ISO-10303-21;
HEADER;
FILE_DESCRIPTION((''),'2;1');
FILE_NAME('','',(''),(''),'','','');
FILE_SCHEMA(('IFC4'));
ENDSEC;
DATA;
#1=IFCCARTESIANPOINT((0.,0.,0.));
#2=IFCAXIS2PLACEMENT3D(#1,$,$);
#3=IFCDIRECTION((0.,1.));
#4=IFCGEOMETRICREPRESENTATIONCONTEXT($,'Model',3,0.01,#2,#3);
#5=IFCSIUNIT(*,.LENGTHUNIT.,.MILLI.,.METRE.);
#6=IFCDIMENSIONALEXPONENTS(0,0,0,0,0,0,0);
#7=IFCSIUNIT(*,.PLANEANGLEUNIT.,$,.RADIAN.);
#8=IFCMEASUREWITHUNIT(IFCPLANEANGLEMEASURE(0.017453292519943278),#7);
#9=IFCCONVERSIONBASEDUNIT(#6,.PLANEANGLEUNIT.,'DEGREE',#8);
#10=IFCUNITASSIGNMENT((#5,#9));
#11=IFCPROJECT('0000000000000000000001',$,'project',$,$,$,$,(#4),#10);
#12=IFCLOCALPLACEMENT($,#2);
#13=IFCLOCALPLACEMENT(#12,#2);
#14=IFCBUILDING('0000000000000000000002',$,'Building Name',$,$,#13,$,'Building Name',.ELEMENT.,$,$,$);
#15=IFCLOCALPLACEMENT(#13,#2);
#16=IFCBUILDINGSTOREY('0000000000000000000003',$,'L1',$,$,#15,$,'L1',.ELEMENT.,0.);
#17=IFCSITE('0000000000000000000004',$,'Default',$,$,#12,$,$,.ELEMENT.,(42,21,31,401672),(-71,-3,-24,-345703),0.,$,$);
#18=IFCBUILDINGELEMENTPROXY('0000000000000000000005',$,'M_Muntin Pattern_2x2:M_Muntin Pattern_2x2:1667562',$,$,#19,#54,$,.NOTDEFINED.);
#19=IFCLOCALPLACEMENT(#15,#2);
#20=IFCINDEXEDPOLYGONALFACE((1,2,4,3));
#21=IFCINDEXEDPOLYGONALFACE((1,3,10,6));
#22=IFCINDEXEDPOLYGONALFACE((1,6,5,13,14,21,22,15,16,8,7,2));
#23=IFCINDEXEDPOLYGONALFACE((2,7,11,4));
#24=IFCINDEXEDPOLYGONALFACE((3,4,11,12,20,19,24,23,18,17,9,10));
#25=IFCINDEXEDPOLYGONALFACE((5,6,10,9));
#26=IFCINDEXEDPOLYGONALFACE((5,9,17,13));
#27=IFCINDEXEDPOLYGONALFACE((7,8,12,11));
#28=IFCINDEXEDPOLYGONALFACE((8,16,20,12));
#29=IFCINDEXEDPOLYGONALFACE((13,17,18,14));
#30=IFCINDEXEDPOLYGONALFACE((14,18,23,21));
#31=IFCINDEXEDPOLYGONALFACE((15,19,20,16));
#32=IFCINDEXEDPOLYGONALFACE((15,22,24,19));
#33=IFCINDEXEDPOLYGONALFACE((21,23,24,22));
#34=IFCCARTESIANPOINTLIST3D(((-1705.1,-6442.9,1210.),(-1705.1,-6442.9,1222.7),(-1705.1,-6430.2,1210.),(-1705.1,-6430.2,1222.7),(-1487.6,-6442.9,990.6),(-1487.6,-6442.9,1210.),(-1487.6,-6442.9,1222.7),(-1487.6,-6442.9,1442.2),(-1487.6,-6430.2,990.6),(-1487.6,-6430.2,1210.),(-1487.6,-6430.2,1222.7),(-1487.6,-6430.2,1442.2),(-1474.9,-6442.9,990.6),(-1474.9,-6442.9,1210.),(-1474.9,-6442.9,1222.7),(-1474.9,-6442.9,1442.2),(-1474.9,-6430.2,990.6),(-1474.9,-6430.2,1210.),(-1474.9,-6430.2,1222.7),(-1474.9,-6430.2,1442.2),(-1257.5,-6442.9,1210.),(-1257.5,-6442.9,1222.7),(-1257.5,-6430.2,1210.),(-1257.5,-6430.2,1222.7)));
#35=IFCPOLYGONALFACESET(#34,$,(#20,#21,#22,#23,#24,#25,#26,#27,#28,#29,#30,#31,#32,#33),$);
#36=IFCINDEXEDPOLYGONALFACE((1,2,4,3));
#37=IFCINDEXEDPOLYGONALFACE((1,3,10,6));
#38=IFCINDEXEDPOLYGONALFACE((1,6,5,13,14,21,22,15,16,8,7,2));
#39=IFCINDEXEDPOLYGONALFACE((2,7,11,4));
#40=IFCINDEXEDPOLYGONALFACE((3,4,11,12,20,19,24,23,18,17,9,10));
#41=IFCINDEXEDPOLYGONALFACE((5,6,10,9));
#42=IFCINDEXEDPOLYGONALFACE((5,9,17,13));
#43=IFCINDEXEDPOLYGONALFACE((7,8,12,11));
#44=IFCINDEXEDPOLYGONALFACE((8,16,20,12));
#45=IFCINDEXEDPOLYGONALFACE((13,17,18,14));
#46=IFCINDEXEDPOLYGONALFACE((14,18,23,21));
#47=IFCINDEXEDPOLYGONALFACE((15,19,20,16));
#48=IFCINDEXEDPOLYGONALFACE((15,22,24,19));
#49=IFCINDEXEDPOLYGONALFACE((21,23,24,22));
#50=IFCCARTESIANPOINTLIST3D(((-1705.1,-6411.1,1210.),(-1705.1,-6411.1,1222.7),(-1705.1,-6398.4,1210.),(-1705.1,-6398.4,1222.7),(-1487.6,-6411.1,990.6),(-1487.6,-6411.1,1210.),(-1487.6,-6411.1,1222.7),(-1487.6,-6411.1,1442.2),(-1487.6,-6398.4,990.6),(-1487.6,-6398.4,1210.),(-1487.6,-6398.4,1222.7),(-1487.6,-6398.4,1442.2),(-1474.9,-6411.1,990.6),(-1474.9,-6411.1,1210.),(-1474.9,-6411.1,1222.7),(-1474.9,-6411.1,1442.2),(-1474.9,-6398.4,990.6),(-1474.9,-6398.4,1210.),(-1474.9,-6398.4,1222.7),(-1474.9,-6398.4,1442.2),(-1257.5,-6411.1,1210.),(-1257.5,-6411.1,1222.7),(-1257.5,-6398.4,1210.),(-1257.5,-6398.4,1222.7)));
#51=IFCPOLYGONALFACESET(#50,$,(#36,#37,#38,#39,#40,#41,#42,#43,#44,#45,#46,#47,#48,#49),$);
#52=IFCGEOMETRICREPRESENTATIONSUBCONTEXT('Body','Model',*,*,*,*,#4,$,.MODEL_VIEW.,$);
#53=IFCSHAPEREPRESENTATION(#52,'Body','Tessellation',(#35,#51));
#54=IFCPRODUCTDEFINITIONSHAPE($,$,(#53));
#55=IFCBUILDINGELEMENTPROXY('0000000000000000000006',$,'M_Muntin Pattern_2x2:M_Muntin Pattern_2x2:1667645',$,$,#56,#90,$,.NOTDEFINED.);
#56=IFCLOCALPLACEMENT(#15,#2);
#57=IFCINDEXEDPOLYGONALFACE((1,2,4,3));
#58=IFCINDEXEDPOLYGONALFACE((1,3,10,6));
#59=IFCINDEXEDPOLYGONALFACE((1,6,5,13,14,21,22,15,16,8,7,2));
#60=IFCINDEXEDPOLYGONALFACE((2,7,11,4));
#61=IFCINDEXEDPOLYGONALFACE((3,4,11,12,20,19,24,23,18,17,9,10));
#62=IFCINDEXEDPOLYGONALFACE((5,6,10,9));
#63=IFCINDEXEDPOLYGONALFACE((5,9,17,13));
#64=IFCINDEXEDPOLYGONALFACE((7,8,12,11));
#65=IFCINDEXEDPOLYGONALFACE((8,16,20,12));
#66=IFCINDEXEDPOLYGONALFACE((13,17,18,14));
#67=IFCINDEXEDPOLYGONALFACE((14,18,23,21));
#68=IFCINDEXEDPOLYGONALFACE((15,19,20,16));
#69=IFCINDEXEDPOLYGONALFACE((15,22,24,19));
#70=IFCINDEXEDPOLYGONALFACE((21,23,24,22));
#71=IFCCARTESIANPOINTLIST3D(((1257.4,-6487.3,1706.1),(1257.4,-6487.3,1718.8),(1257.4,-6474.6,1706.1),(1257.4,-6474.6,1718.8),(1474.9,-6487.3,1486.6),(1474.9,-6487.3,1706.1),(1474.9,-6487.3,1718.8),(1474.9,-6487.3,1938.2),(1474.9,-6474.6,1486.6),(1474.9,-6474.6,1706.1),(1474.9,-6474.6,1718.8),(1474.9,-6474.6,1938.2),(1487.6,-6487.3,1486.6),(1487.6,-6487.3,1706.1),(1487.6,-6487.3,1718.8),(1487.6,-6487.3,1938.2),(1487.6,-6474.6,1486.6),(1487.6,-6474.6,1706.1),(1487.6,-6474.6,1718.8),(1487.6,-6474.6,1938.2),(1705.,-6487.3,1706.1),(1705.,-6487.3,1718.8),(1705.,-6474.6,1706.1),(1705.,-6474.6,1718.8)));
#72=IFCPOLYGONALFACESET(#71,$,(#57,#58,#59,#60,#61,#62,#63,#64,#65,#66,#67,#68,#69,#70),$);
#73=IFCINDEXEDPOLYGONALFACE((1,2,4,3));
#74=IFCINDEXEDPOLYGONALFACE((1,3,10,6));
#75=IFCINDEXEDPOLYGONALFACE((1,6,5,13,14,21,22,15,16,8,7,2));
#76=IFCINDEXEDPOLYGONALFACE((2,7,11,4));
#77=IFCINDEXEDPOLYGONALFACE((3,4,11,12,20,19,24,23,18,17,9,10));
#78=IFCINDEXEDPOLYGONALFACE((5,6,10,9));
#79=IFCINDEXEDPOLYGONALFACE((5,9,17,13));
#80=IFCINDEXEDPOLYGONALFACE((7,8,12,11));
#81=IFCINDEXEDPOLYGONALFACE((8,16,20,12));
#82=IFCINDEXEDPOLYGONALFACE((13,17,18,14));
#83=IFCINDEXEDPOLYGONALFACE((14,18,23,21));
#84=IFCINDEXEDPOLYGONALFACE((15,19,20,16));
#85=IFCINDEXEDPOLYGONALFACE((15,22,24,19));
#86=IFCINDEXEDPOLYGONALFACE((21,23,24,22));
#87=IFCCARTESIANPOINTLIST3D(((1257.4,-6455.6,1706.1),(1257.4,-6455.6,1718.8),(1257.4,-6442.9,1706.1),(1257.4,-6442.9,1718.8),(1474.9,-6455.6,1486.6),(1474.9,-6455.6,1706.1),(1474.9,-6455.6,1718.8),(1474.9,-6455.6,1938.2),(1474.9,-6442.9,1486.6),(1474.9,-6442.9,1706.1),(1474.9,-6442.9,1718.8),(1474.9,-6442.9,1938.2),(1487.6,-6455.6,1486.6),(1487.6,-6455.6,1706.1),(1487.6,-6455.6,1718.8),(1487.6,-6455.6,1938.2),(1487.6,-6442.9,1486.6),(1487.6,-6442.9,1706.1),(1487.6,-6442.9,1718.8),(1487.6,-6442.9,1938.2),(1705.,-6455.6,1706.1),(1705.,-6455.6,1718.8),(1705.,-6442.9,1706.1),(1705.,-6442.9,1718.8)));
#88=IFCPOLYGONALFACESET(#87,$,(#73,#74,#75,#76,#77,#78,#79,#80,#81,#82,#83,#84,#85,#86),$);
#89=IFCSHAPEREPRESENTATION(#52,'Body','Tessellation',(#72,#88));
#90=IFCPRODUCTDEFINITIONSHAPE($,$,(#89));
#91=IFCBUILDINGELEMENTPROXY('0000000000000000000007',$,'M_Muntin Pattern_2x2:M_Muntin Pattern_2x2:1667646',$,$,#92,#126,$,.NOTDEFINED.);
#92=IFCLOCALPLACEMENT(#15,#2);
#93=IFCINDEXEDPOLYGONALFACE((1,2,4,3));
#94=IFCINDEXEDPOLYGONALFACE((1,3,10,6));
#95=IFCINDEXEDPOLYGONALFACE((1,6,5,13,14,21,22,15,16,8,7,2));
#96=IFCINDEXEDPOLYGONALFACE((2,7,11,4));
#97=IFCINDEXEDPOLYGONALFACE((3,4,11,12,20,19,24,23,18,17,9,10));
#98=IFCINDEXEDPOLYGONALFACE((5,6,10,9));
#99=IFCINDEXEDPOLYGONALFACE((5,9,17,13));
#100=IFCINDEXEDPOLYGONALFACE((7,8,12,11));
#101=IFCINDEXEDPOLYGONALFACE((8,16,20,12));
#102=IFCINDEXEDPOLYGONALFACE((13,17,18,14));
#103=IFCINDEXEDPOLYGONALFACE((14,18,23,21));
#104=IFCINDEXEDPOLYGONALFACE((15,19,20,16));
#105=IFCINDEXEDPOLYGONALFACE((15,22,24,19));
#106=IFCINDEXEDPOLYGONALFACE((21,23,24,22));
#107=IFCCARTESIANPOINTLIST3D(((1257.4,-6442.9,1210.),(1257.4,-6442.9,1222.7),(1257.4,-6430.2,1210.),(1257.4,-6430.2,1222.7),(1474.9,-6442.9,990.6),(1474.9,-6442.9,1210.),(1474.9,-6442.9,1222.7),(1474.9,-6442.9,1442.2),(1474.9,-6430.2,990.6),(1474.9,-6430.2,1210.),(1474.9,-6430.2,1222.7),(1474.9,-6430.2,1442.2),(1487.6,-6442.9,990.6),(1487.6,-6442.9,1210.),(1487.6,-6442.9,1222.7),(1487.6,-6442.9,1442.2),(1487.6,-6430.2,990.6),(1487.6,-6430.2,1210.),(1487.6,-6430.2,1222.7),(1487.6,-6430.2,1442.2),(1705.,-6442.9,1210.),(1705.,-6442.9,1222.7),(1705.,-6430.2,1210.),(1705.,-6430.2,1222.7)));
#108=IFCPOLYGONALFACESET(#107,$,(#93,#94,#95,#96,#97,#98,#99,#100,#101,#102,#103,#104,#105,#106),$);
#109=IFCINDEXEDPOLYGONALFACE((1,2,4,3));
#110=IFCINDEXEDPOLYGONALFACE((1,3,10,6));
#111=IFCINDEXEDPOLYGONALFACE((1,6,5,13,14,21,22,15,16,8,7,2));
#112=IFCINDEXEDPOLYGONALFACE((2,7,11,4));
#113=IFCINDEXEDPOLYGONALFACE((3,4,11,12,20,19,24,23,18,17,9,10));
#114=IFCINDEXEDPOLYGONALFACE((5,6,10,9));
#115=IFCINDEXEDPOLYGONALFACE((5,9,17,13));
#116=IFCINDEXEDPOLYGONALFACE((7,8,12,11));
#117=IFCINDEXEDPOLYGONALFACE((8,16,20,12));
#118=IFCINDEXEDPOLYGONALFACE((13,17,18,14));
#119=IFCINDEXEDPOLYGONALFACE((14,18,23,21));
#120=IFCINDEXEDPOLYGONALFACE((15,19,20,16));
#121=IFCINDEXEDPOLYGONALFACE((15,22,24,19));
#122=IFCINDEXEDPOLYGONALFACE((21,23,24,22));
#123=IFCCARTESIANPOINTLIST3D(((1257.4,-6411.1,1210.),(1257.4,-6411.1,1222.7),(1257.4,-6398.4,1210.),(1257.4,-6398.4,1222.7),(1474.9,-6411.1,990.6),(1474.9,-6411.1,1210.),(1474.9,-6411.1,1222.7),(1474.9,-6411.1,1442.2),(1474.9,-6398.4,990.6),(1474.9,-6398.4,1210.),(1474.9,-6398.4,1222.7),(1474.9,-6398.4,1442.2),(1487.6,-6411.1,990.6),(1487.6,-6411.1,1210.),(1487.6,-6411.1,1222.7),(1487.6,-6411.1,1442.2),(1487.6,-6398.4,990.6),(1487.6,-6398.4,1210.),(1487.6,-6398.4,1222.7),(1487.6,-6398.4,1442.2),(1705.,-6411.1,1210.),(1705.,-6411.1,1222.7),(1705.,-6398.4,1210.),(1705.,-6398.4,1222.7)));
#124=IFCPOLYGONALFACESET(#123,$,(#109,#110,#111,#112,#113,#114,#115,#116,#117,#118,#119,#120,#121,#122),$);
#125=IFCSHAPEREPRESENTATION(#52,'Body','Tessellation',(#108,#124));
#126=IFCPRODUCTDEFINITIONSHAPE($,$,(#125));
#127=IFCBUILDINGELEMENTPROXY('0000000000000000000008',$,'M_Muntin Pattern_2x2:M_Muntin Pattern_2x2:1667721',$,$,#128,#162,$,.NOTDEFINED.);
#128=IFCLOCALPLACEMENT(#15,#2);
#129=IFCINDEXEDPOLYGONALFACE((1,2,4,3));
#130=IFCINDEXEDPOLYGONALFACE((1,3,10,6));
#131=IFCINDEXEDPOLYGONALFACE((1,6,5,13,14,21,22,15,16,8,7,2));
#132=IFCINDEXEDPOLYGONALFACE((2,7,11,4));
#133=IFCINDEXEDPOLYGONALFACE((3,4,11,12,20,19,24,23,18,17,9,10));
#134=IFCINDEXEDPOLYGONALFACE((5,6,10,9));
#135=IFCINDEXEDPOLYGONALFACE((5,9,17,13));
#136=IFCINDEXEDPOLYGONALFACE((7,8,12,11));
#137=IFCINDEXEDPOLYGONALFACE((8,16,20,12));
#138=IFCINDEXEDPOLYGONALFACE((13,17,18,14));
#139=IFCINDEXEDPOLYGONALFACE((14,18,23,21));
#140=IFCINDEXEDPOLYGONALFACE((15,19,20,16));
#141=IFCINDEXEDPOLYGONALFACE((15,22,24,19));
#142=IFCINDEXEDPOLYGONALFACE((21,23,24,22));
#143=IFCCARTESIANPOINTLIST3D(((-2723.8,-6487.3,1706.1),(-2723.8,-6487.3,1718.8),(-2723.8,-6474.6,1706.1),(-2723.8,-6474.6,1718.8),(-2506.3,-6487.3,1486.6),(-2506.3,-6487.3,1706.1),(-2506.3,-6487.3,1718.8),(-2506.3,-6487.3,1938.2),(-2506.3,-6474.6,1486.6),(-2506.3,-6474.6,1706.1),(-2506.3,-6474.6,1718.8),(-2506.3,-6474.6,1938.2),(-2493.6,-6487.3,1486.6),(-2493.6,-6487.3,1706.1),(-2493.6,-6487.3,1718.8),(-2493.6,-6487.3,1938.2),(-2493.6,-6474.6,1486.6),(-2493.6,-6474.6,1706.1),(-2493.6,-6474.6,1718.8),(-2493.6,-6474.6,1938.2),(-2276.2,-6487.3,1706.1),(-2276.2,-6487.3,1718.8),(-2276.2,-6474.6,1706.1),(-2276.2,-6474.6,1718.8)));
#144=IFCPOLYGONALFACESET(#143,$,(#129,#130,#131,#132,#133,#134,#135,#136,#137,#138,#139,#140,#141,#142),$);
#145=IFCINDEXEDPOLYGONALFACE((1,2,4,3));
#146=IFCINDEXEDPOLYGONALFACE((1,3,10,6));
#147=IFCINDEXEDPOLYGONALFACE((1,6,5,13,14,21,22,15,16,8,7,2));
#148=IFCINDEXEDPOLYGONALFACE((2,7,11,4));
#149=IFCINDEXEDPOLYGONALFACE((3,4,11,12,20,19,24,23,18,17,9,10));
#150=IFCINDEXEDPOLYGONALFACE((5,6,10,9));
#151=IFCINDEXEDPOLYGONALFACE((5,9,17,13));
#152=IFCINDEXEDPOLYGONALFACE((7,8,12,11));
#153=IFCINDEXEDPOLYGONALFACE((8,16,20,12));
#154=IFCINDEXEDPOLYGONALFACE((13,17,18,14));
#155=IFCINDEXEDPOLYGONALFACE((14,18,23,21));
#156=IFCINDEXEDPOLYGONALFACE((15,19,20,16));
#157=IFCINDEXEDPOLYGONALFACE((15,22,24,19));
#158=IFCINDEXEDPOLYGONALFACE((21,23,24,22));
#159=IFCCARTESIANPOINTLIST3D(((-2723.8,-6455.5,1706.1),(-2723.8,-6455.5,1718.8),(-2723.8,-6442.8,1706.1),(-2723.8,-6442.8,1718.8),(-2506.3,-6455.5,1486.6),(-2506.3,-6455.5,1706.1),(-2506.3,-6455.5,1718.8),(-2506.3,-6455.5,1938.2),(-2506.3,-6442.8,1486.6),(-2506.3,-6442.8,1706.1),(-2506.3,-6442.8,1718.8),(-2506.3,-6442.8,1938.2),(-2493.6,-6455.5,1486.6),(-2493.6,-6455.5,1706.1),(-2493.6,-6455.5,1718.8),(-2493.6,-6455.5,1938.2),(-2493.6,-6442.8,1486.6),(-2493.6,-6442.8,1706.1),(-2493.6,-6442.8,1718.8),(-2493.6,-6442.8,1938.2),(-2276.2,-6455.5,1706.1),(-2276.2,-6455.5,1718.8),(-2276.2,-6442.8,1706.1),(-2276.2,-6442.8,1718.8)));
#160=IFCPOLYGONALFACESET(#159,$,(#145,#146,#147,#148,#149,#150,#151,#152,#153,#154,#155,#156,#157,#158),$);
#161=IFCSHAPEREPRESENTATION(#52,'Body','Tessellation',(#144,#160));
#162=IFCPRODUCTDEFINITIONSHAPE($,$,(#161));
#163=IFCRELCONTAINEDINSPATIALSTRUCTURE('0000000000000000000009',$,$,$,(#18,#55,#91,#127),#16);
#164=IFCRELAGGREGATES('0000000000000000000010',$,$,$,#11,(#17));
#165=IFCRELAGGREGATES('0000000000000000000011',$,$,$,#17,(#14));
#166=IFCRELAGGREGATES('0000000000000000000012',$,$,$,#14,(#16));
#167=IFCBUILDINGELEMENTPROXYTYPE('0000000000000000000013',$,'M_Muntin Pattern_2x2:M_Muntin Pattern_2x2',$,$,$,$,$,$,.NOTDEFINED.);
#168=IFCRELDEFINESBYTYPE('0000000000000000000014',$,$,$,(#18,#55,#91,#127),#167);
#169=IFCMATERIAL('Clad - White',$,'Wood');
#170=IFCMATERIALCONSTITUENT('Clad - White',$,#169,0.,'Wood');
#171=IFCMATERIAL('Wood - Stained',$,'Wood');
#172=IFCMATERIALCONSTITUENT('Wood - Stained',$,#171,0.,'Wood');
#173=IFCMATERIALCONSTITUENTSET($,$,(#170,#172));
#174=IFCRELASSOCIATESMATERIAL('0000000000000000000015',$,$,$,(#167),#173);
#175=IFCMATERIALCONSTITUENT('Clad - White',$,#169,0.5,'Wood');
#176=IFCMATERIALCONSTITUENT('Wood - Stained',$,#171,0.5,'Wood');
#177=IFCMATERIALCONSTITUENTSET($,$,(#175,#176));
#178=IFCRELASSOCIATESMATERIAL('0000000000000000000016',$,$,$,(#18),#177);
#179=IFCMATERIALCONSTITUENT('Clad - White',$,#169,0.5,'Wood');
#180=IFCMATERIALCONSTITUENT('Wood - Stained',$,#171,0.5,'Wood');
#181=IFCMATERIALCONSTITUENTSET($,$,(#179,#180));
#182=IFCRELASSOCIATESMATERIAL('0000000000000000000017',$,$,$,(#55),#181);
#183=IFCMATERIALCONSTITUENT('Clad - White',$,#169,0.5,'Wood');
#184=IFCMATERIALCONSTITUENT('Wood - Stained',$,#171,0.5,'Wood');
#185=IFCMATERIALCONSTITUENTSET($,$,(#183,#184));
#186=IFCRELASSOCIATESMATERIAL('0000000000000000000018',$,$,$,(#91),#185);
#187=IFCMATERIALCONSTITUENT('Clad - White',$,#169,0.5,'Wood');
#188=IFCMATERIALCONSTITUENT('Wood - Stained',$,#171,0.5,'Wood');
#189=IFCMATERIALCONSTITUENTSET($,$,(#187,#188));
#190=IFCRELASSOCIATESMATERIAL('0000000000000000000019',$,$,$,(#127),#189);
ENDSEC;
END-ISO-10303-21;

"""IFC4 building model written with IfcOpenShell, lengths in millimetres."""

from ifc_helpers import new_model, entity, si_unit, converted_unit, direction, frame, origin, place, context, subcontext, project, spatial, indexed_curve, outline, extrude, source, transform, mapped, material, constituent, constituent_set, type_object, type_shapes, element, save


model = new_model("IFC4")

# Units and contexts
model_context = context("Model", 3, precision=0.01, world=origin(), true_north=direction((0.0, 1.0)))
body_context = subcontext(model_context, "Body", "Model", "MODEL_VIEW")
ifc_project = project(units=[si_unit("LENGTHUNIT", "METRE", prefix="MILLI"), converted_unit("PLANEANGLEUNIT", "DEGREE", entity("IfcPlaneAngleMeasure", 0.017453292519943278), si_unit("PLANEANGLEUNIT", "RADIAN"), dimensions=[0, 0, 0, 0, 0, 0, 0])], contexts=[model_context])

# Site, building, storey
site_placement = place(None, origin())
site = spatial("IfcSite", under=ifc_project, at=site_placement, Name="Default", CompositionType="ELEMENT", RefLatitude=(42, 21, 31, 401672), RefLongitude=(-71, -3, -24, -345703), RefElevation=0.0)
building_placement = place(site_placement, origin())
building = spatial("IfcBuilding", under=site, at=building_placement, Name="Building Name", LongName="Building Name", CompositionType="ELEMENT")
storey_placement = place(building_placement, origin())
storey = spatial("IfcBuildingStorey", under=building, at=storey_placement, Name="L1", LongName="L1", CompositionType="ELEMENT", Elevation=0.0)

# Building element proxies
ifc_material_1 = material(Name="Clad - White", Category="Wood")
ifc_material_2 = material(Name="Wood - Stained", Category="Wood")
ifc_constituent_1 = constituent(ifc_material_1, Name="Clad - White", Category="Wood", fraction=0.0)
ifc_constituent_2 = constituent(ifc_material_2, Name="Wood - Stained", Category="Wood", fraction=0.0)
ifc_constituent_set_1 = constituent_set(constituents=[ifc_constituent_1, ifc_constituent_2])
building_element_proxy_type_1 = type_object("IfcBuildingElementProxyType", Name="M_Muntin Pattern_2x2:M_Muntin Pattern_2x2", PredefinedType="NOTDEFINED", material=ifc_constituent_set_1)
shared_shape_1 = source(origin(), body_context, "Body", "SweptSolid", [
    extrude(outline(indexed_curve([(6.4, -6.4), (225.8, -6.4), (225.8, 6.3), (6.4, 6.3), (6.4, 223.8), (-6.3, 223.8), (-6.3, 6.3), (-225.8, 6.3), (-225.8, -6.4), (-6.3, -6.4), (-6.3, -223.8), (6.4, -223.8), (6.4, -6.4)], self_intersect=False)), frame((0.0, 9.5, 225.8), z_axis=(0.0, 1.0, 0.0), x_axis=(0.0, 0.0, 1.0)), (0.0, 0.0, 1.0), 12.7),
    extrude(outline(indexed_curve([(6.4, -6.4), (225.8, -6.4), (225.8, 6.3), (6.4, 6.3), (6.4, 223.8), (-6.3, 223.8), (-6.3, 6.3), (-225.8, 6.3), (-225.8, -6.4), (-6.3, -6.4), (-6.3, -223.8), (6.4, -223.8), (6.4, -6.4)], self_intersect=False)), frame((0.0, -22.2, 225.8), z_axis=(0.0, 1.0, 0.0), x_axis=(0.0, 0.0, 1.0)), (0.0, 0.0, 1.0), 12.7),
])
type_shapes(building_element_proxy_type_1, [shared_shape_1])
ifc_constituent_3 = constituent(ifc_material_1, Name="Clad - White", Category="Wood", fraction=0.5)
ifc_constituent_4 = constituent(ifc_material_2, Name="Wood - Stained", Category="Wood", fraction=0.5)
ifc_constituent_set_2 = constituent_set(constituents=[ifc_constituent_3, ifc_constituent_4])
proxy_1_placement = place(storey_placement, frame((-1481.2, -6420.6, 990.6), z_axis=(0.0, 0.0, 1.0), x_axis=(-1.0, 0.0, 0.0)))
element("IfcBuildingElementProxy", 1, at=proxy_1_placement, inside=storey, type_object=building_element_proxy_type_1, material=ifc_constituent_set_2, Name="M_Muntin Pattern_2x2:M_Muntin Pattern_2x2:1667562", PredefinedType="NOTDEFINED", context=body_context, shape_type="MappedRepresentation", body=[
    mapped(shared_shape_1, transform((0.0, 0.0, 0.0), scale=1.0)),
])
ifc_constituent_5 = constituent(ifc_material_1, Name="Clad - White", Category="Wood", fraction=0.5)
ifc_constituent_6 = constituent(ifc_material_2, Name="Wood - Stained", Category="Wood", fraction=0.5)
ifc_constituent_set_3 = constituent_set(constituents=[ifc_constituent_5, ifc_constituent_6])
proxy_2_placement = place(storey_placement, frame((1481.3, -6465.1, 1486.6), z_axis=(0.0, 0.0, 1.0), x_axis=(-1.0, 0.0, 0.0)))
element("IfcBuildingElementProxy", 2, at=proxy_2_placement, inside=storey, type_object=building_element_proxy_type_1, material=ifc_constituent_set_3, Name="M_Muntin Pattern_2x2:M_Muntin Pattern_2x2:1667645", PredefinedType="NOTDEFINED", context=body_context, shape_type="MappedRepresentation", body=[
    mapped(shared_shape_1, transform((0.0, 0.0, 0.0), scale=1.0)),
])
ifc_constituent_7 = constituent(ifc_material_1, Name="Clad - White", Category="Wood", fraction=0.5)
ifc_constituent_8 = constituent(ifc_material_2, Name="Wood - Stained", Category="Wood", fraction=0.5)
ifc_constituent_set_4 = constituent_set(constituents=[ifc_constituent_7, ifc_constituent_8])
proxy_3_placement = place(storey_placement, frame((1481.3, -6420.6, 990.6), z_axis=(0.0, 0.0, 1.0), x_axis=(-1.0, 0.0, 0.0)))
element("IfcBuildingElementProxy", 3, at=proxy_3_placement, inside=storey, type_object=building_element_proxy_type_1, material=ifc_constituent_set_4, Name="M_Muntin Pattern_2x2:M_Muntin Pattern_2x2:1667646", PredefinedType="NOTDEFINED", context=body_context, shape_type="MappedRepresentation", body=[
    mapped(shared_shape_1, transform((0.0, 0.0, 0.0), scale=1.0)),
])
ifc_constituent_9 = constituent(ifc_material_1, Name="Clad - White", Category="Wood", fraction=0.5)
ifc_constituent_10 = constituent(ifc_material_2, Name="Wood - Stained", Category="Wood", fraction=0.5)
ifc_constituent_set_5 = constituent_set(constituents=[ifc_constituent_9, ifc_constituent_10])
proxy_4_placement = place(storey_placement, frame((-2500.0, -6465.1, 1486.6), z_axis=(0.0, 0.0, 1.0), x_axis=(-1.0, 0.0, 0.0)))
element("IfcBuildingElementProxy", 4, at=proxy_4_placement, inside=storey, type_object=building_element_proxy_type_1, material=ifc_constituent_set_5, Name="M_Muntin Pattern_2x2:M_Muntin Pattern_2x2:1667721", PredefinedType="NOTDEFINED", context=body_context, shape_type="MappedRepresentation", body=[
    mapped(shared_shape_1, transform((0.0, 0.0, 0.0), scale=1.0)),
])

save(model, "model.ifc")
